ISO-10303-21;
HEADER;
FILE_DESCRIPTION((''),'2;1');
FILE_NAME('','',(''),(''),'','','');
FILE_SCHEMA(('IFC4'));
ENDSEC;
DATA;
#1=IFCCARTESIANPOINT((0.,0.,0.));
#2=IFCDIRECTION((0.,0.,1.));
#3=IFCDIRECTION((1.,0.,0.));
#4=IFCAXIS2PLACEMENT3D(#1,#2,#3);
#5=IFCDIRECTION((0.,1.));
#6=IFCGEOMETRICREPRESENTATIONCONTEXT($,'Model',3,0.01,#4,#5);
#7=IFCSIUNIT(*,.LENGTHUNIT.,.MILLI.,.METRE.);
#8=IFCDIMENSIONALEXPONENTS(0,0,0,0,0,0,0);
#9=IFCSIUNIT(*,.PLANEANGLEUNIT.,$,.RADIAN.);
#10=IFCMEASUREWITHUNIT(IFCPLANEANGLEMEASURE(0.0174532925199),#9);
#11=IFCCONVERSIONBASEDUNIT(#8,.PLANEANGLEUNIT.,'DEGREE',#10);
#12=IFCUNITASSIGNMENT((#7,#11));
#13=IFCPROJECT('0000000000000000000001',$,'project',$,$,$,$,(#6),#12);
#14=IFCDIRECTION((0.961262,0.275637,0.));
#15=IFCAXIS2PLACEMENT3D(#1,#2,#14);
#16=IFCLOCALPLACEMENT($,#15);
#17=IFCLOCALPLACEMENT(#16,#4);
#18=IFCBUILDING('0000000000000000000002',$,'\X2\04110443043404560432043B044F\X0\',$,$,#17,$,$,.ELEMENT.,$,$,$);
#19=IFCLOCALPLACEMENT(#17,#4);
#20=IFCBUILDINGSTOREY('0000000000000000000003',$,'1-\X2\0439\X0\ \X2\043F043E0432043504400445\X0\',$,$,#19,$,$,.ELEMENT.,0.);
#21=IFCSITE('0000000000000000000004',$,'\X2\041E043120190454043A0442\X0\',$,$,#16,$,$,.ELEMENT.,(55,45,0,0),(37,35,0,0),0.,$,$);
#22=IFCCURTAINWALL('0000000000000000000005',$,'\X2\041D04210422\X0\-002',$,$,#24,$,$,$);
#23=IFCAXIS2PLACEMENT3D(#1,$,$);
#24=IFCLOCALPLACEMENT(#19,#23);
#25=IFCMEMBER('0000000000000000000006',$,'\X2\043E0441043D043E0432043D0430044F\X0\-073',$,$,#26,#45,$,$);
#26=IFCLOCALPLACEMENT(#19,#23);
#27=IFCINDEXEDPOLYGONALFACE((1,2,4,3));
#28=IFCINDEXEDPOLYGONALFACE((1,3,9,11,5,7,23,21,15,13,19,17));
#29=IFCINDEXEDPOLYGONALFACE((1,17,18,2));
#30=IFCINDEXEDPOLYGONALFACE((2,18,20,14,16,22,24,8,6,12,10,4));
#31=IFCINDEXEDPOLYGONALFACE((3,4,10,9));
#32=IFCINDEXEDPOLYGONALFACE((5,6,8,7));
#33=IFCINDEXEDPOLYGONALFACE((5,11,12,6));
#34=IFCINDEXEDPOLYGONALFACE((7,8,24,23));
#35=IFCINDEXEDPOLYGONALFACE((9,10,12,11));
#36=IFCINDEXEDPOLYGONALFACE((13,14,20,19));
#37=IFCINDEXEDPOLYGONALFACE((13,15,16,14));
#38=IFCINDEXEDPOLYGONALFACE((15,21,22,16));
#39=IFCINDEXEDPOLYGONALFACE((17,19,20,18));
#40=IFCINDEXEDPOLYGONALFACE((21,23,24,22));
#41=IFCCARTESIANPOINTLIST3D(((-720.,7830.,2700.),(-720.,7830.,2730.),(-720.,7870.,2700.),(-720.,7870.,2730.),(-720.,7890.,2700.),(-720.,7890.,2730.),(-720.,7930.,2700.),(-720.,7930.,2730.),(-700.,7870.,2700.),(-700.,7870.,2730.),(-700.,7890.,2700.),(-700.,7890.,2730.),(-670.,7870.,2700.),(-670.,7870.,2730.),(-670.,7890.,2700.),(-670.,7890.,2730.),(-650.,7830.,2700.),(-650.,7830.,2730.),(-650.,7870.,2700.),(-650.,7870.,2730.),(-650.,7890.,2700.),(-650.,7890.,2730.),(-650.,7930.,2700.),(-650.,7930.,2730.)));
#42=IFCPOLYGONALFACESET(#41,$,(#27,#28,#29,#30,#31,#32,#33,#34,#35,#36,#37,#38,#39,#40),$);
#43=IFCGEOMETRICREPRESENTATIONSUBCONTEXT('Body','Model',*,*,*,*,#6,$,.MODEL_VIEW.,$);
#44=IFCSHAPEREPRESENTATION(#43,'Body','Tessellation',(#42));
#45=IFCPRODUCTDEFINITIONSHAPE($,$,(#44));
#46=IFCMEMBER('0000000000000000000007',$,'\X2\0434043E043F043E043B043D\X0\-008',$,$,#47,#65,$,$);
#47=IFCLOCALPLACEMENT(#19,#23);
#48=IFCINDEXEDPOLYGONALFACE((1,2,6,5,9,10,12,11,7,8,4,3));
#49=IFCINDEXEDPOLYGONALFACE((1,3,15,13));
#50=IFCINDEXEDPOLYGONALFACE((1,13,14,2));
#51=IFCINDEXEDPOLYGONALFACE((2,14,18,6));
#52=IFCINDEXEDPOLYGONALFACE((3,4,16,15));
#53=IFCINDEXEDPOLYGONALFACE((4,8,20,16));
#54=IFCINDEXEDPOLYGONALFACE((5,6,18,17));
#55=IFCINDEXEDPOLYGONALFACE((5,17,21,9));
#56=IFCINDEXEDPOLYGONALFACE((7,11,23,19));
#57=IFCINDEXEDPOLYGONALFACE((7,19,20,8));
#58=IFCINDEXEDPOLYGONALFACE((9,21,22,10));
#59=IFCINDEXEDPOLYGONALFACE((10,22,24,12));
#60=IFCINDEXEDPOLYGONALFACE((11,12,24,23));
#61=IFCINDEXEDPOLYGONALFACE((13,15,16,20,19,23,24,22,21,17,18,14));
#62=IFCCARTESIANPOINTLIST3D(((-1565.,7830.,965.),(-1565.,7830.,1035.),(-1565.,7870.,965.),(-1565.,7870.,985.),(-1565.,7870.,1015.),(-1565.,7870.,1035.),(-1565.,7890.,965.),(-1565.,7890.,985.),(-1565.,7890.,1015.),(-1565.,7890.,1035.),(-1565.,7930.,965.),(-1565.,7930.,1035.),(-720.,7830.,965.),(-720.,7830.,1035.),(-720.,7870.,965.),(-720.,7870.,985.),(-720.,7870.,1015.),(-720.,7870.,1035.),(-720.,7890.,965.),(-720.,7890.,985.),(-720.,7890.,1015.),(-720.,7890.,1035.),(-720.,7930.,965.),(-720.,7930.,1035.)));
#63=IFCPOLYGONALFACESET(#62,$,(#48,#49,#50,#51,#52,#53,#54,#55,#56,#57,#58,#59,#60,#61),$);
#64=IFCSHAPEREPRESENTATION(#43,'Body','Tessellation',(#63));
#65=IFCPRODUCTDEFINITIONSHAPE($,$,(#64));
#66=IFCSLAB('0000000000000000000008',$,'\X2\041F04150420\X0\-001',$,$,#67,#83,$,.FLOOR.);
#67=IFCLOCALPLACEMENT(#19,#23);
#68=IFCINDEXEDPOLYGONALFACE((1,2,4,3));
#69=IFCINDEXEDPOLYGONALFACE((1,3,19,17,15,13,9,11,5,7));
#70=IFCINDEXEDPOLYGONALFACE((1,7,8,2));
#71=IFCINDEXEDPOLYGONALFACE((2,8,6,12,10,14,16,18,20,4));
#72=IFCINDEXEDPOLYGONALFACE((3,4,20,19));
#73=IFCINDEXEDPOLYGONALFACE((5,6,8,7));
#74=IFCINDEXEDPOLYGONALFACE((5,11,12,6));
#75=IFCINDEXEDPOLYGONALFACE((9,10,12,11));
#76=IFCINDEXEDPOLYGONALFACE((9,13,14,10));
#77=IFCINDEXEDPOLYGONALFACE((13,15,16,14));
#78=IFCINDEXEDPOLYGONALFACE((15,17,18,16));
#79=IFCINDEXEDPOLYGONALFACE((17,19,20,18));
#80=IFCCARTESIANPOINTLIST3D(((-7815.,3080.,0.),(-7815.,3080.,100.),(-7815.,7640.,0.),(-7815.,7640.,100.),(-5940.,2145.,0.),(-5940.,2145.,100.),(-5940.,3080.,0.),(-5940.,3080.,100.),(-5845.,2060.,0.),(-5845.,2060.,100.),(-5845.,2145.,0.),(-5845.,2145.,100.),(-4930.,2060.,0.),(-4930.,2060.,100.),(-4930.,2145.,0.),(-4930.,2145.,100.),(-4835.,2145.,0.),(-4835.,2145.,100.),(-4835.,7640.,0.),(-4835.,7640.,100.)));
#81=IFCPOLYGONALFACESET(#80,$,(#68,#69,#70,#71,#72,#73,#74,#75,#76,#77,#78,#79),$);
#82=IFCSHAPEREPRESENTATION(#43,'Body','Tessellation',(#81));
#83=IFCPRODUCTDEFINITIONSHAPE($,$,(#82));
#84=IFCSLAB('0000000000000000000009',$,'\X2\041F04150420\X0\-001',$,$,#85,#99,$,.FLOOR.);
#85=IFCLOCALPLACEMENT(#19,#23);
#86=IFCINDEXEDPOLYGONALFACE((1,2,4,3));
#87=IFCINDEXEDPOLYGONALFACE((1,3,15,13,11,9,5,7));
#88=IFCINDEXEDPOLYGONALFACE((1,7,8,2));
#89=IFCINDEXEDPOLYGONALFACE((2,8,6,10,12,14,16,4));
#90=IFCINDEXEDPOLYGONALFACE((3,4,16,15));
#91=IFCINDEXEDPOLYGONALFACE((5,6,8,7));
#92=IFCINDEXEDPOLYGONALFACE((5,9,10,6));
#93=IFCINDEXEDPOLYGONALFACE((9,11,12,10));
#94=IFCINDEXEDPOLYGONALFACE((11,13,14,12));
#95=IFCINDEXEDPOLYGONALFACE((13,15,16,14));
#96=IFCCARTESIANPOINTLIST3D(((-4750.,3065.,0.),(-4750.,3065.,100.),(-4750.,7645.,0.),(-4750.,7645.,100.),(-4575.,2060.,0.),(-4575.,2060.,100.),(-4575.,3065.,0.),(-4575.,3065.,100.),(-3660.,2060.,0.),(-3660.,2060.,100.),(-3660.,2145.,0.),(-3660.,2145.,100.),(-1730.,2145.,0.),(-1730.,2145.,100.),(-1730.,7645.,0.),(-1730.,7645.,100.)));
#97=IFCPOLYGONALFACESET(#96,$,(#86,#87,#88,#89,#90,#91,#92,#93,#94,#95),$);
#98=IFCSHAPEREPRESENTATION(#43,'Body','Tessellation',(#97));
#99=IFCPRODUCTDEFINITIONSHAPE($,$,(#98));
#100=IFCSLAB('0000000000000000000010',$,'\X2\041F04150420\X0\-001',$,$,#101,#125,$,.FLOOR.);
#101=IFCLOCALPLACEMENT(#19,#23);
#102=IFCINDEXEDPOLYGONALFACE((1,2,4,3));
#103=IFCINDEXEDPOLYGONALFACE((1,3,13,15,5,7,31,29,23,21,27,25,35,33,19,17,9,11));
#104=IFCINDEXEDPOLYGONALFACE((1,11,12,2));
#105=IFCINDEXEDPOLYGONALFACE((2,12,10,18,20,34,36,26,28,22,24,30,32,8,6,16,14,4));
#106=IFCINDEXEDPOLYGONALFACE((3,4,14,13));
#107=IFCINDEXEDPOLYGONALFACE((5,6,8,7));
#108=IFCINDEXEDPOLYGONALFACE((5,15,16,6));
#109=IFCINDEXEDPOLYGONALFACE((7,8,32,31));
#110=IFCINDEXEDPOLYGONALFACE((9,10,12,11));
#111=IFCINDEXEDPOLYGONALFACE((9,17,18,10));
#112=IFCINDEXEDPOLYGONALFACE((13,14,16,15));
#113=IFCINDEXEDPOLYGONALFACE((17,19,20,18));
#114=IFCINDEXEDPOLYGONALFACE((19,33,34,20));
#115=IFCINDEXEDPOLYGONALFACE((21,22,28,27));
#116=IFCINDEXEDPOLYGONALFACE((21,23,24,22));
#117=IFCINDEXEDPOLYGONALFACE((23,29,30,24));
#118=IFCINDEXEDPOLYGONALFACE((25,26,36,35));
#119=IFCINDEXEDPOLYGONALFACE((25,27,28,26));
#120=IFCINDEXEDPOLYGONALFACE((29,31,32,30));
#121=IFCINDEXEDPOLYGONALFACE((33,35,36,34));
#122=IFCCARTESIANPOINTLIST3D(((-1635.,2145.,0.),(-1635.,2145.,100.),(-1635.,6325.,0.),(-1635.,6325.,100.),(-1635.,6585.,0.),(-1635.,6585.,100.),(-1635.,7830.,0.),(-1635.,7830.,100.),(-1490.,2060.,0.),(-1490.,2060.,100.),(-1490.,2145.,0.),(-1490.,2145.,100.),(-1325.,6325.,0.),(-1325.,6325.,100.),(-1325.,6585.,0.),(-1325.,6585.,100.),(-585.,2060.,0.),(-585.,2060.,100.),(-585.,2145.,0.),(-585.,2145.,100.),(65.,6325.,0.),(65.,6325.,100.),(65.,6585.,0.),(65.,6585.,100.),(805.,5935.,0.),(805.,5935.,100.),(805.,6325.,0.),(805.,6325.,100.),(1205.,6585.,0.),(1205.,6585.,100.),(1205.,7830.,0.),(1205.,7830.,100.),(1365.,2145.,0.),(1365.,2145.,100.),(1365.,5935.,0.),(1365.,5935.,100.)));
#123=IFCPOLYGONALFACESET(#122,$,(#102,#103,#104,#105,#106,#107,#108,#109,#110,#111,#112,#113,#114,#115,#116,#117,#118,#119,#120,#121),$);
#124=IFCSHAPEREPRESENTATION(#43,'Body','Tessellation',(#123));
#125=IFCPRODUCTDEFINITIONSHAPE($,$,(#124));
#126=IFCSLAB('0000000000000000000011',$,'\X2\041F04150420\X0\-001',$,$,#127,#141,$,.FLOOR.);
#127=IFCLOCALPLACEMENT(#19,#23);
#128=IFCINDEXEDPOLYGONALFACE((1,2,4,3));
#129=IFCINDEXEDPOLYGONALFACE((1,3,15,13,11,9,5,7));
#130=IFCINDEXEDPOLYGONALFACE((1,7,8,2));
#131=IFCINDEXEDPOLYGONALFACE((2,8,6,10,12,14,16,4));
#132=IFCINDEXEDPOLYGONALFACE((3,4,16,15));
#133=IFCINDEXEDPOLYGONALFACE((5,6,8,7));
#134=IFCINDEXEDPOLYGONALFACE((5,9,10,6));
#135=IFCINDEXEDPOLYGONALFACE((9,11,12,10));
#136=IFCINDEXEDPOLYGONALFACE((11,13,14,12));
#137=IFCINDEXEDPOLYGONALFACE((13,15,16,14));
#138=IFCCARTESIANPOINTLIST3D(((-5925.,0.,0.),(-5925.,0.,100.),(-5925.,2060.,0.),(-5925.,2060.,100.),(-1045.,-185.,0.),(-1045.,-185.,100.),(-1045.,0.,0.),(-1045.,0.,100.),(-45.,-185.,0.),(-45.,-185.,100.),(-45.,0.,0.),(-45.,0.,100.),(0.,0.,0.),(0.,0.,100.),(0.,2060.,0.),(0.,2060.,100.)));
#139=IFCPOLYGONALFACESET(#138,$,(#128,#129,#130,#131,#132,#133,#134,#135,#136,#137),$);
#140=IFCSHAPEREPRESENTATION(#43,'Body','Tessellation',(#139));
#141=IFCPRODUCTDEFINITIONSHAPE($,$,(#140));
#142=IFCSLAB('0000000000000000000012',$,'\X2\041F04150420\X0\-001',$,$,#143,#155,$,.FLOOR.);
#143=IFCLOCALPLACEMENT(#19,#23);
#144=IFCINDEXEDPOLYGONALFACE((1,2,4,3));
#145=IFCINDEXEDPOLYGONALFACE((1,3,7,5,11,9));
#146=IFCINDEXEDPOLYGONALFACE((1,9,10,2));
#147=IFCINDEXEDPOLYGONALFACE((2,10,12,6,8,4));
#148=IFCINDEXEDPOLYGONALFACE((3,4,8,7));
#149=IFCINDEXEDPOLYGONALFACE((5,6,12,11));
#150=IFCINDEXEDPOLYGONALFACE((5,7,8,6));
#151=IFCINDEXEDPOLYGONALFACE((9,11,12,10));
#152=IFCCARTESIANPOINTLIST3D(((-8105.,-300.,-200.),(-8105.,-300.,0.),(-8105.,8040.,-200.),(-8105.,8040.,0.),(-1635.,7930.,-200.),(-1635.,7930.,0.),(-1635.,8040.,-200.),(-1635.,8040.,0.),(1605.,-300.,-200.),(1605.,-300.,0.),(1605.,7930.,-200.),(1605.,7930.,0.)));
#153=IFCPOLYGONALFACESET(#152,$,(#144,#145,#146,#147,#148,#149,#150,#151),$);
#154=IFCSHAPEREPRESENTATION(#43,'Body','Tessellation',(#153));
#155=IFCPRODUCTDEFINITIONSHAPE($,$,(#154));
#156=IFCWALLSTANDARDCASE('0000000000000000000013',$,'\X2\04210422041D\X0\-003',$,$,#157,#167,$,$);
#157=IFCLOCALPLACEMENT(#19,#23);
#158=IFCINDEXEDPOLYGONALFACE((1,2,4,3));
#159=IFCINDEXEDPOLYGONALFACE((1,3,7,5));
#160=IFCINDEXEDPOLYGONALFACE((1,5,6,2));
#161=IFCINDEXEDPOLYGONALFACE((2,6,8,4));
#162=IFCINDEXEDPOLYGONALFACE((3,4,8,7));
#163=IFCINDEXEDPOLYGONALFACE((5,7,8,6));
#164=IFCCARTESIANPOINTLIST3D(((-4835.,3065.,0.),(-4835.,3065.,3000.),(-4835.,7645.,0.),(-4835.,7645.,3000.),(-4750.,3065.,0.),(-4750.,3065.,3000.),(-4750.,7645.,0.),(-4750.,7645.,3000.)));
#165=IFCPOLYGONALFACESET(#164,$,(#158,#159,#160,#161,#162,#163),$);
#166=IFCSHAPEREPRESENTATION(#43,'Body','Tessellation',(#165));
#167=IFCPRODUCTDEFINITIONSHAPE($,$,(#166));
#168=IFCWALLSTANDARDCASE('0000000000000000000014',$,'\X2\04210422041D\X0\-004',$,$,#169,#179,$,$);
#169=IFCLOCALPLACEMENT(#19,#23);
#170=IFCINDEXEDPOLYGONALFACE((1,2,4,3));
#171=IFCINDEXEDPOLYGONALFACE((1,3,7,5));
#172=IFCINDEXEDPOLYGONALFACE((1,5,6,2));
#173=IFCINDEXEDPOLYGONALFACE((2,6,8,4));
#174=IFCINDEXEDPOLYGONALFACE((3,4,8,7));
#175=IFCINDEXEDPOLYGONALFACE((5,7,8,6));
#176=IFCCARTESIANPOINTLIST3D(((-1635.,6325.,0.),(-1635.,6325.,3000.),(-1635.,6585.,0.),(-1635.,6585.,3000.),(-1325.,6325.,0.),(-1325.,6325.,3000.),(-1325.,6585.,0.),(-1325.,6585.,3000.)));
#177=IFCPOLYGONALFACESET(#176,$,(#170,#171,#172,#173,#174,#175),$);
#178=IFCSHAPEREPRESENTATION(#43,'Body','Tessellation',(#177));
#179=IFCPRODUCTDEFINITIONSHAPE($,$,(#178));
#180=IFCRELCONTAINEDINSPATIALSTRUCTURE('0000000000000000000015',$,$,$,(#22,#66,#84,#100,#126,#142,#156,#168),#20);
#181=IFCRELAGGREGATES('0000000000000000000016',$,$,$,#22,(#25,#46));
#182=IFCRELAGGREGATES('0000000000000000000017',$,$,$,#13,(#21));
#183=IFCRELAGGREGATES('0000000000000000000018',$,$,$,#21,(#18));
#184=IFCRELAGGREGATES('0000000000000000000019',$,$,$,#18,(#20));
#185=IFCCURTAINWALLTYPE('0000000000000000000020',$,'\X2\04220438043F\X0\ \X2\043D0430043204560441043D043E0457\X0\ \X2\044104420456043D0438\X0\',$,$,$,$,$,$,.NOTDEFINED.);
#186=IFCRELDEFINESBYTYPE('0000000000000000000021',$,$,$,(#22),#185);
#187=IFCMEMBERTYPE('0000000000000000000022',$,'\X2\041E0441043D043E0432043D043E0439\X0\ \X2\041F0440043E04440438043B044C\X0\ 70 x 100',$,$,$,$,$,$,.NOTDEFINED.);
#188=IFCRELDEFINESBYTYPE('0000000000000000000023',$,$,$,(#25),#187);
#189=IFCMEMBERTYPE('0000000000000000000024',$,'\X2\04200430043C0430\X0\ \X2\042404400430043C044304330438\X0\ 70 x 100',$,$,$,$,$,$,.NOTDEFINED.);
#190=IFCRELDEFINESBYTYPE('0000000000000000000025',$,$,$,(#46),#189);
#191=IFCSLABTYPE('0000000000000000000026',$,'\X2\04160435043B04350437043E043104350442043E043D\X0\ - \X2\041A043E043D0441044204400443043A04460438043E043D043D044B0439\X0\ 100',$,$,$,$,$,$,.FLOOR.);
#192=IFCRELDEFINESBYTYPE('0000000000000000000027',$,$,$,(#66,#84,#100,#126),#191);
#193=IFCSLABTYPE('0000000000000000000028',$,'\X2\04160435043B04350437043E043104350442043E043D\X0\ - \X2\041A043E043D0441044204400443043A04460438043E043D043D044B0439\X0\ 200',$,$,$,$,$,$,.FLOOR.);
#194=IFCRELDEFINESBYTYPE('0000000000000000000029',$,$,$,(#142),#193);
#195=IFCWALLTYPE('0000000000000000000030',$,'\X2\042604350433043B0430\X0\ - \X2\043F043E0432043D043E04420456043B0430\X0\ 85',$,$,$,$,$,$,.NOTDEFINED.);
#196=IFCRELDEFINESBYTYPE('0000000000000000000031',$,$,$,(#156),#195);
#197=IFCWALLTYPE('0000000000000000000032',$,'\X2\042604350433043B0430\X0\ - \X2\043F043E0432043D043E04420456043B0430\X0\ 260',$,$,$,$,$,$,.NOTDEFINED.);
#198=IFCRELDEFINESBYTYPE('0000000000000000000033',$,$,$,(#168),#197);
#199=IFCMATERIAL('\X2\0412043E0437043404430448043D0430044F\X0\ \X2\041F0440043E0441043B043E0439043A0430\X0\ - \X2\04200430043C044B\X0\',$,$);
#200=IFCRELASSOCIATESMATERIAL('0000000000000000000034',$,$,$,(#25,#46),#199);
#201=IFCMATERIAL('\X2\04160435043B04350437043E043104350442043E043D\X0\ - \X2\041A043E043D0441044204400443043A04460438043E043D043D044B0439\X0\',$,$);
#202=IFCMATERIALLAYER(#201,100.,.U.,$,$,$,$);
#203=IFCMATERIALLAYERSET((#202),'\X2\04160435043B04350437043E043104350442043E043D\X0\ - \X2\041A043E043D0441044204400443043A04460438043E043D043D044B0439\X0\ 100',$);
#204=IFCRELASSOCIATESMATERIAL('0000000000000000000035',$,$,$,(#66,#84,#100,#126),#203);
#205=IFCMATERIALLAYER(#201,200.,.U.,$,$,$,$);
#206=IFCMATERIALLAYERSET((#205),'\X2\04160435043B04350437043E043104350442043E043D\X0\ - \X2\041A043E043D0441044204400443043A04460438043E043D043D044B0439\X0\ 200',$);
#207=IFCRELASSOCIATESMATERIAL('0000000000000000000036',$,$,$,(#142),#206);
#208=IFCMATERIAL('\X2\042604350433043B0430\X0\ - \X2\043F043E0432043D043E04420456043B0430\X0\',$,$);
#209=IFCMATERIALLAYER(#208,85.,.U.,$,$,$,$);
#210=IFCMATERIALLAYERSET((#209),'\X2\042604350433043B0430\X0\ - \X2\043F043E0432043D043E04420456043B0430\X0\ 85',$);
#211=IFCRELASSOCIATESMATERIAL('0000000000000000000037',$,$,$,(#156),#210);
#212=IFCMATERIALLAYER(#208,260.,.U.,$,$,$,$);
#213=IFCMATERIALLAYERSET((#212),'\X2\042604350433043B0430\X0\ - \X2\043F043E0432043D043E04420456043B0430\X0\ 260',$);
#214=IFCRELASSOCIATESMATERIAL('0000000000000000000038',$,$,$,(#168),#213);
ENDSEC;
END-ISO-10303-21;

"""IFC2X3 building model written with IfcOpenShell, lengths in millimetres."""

from ifc_helpers import new_model, entity, si_unit, converted_unit, direction, frame, origin_with_axes, place, context, subcontext, project, spatial, polyline, outline, extrude, material, layer, layer_set, layer_usage, type_object, element, aggregate, save


model = new_model("IFC2X3")

# Units and contexts
model_context = context("Model", 3, precision=0.01, world=origin_with_axes(), true_north=direction((0.0, 1.0)))
body_context = subcontext(model_context, "Body", "Model", "MODEL_VIEW")
ifc_project = project(units=[si_unit("LENGTHUNIT", "METRE", prefix="MILLI"), converted_unit("PLANEANGLEUNIT", "DEGREE", entity("IfcPlaneAngleMeasure", 0.0174532925199), si_unit("PLANEANGLEUNIT", "RADIAN"), dimensions=[0, 0, 0, 0, 0, 0, 0])], contexts=[model_context])

# Site, building, storey
site_placement = place(None, frame((0.0, 0.0, 0.0), z_axis=(0.0, 0.0, 1.0), x_axis=(0.961262, 0.275637, 0.0)))
site = spatial("IfcSite", under=ifc_project, at=site_placement, Name="Об’єкт", CompositionType="ELEMENT", RefLatitude=(55, 45, 0, 0), RefLongitude=(37, 35, 0, 0), RefElevation=0.0)
building_placement = place(site_placement, origin_with_axes())
building = spatial("IfcBuilding", under=site, at=building_placement, Name="Будівля", CompositionType="ELEMENT")
storey_placement = place(building_placement, origin_with_axes())
storey = spatial("IfcBuildingStorey", under=building, at=storey_placement, Name="1-й поверх", CompositionType="ELEMENT", Elevation=0.0)

# Shared definitions
ifc_material_1 = material(Name="Железобетон - Конструкционный")

# Curtain wall, members
curtain_wall_type = type_object("IfcCurtainWallType", Name="Тип навісної стіни", PredefinedType="NOTDEFINED")
curtain_wall_placement = place(storey_placement, frame((-210.0, 7880.0, 100.0), z_axis=(0.0, 0.0, 1.0), x_axis=(1.0, 0.0, 0.0)))
curtain_wall = element("IfcCurtainWall", 1, at=curtain_wall_placement, inside=storey, type_object=curtain_wall_type, Name="НСТ-002")
ifc_material_2 = material(Name="Воздушная Прослойка - Рамы")
member_type_1 = type_object("IfcMemberType", Name="Основной Профиль 70 x 100", PredefinedType="NOTDEFINED")
member_1_placement = place(curtain_wall_placement, frame((-475.0, 0.0, 2600.0), z_axis=(0.0, 0.0, 1.0), x_axis=(1.0, 0.0, 0.0)))
member_1 = element("IfcMember", 2, at=member_1_placement, type_object=member_type_1, material=ifc_material_2, Name="основная-073", context=body_context, shape_type="SweptSolid", body=[
    extrude(outline(polyline([(-15.0, -10.0), (-35.0, -10.0), (-35.0, -50.0), (35.0, -50.0), (35.0, -10.0), (15.0, -10.0), (15.0, 10.0), (35.0, 10.0), (35.0, 50.0), (-35.0, 50.0), (-35.0, 10.0), (-15.0, 10.0), (-15.0, -10.0)])), origin_with_axes(), (0.0, 0.0, 1.0), 30.0),
])
member_type_2 = type_object("IfcMemberType", Name="Рама Фрамуги 70 x 100", PredefinedType="NOTDEFINED")
member_2_placement = place(curtain_wall_placement, frame((-475.0, 0.0, 900.0), z_axis=(-1.0, 0.0, 0.0), x_axis=(0.0, 0.0, 1.0)))
member_2 = element("IfcMember", 3, at=member_2_placement, type_object=member_type_2, material=ifc_material_2, Name="дополн-008", context=body_context, shape_type="SweptSolid", body=[
    extrude(outline(polyline([(-10.0, 15.0), (-10.0, 35.0), (-50.0, 35.0), (-50.0, -35.0), (-10.0, -35.0), (-10.0, -15.0), (10.0, -15.0), (10.0, -35.0), (50.0, -35.0), (50.0, 35.0), (10.0, 35.0), (10.0, 15.0), (-10.0, 15.0)])), frame((0.0, 0.0, 35.0), z_axis=(0.0, 0.0, 1.0), x_axis=(0.0, 1.0, 0.0)), (0.0, 0.0, 1.0), 845.0),
])

# Slabs
ifc_layer_1 = layer(ifc_material_1, 100.0, ventilated="UNKNOWN")
ifc_layer_set_1 = layer_set([ifc_layer_1], Name="Железобетон - Конструкционный 100")
ifc_layer_usage_1 = layer_usage(ifc_layer_set_1, "AXIS3", "NEGATIVE", 100.0)
slab_type_1 = type_object("IfcSlabType", Name="Железобетон - Конструкционный 100", PredefinedType="FLOOR")
slab_1_placement = place(storey_placement, frame((-4835.0, 7640.0, 100.0), z_axis=(0.0, 0.0, 1.0), x_axis=(1.0, 0.0, 0.0)))
element("IfcSlab", 4, at=slab_1_placement, inside=storey, type_object=slab_type_1, material=ifc_layer_usage_1, Name="ПЕР-001", PredefinedType="FLOOR", context=body_context, shape_type="SweptSolid", body=[
    extrude(outline(polyline([(0.0, 0.0), (-2980.0, 0.0), (-2980.0, -4560.0), (-1105.0, -4560.0), (-1105.0, -5495.0), (-1010.0, -5495.0), (-1010.0, -5580.0), (-95.0, -5580.0), (-95.0, -5495.0), (0.0, -5495.0), (0.0, 0.0)])), frame((0.0, 0.0, -100.0), z_axis=(0.0, 0.0, 1.0), x_axis=(1.0, 0.0, 0.0)), (0.0, 0.0, 1.0), 100.0),
])
ifc_layer_usage_2 = layer_usage(ifc_layer_set_1, "AXIS3", "NEGATIVE", 100.0)
slab_2_placement = place(storey_placement, frame((-1730.0, 7645.0, 100.0), z_axis=(0.0, 0.0, 1.0), x_axis=(1.0, 0.0, 0.0)))
element("IfcSlab", 5, at=slab_2_placement, inside=storey, type_object=slab_type_1, material=ifc_layer_usage_2, Name="ПЕР-001", PredefinedType="FLOOR", context=body_context, shape_type="SweptSolid", body=[
    extrude(outline(polyline([(0.0, 0.0), (-3020.0, 0.0), (-3020.0, -4580.0), (-2845.0, -4580.0), (-2845.0, -5585.0), (-1930.0, -5585.0), (-1930.0, -5500.0), (0.0, -5500.0), (0.0, 0.0)])), frame((0.0, 0.0, -100.0), z_axis=(0.0, 0.0, 1.0), x_axis=(1.0, 0.0, 0.0)), (0.0, 0.0, 1.0), 100.0),
])
ifc_layer_usage_3 = layer_usage(ifc_layer_set_1, "AXIS3", "NEGATIVE", 100.0)
slab_3_placement = place(storey_placement, frame((-1635.0, 6585.0, 100.0), z_axis=(0.0, 0.0, 1.0), x_axis=(1.0, 0.0, 0.0)))
element("IfcSlab", 6, at=slab_3_placement, inside=storey, type_object=slab_type_1, material=ifc_layer_usage_3, Name="ПЕР-001", PredefinedType="FLOOR", context=body_context, shape_type="SweptSolid", body=[
    extrude(outline(polyline([(0.0, 0.0), (310.0, 0.0), (310.0, -260.0), (0.0, -260.0), (0.0, -4440.0), (145.0, -4440.0), (145.0, -4525.0), (1050.0, -4525.0), (1050.0, -4440.0), (3000.0, -4440.0), (3000.0, -650.0), (2440.0, -650.0), (2440.0, -260.0), (1700.0, -260.0), (1700.0, 0.0), (2840.0, 0.0), (2840.0, 1245.0), (0.0, 1245.0), (0.0, 0.0)])), frame((0.0, 0.0, -100.0), z_axis=(0.0, 0.0, 1.0), x_axis=(1.0, 0.0, 0.0)), (0.0, 0.0, 1.0), 100.0),
])
ifc_layer_usage_4 = layer_usage(ifc_layer_set_1, "AXIS3", "NEGATIVE", 100.0)
slab_4_placement = place(storey_placement, frame((-5925.0, 0.0, 100.0), z_axis=(0.0, 0.0, 1.0), x_axis=(1.0, 0.0, 0.0)))
element("IfcSlab", 7, at=slab_4_placement, inside=storey, type_object=slab_type_1, material=ifc_layer_usage_4, Name="ПЕР-001", PredefinedType="FLOOR", context=body_context, shape_type="SweptSolid", body=[
    extrude(outline(polyline([(0.0, 0.0), (4880.0, 0.0), (4880.0, -185.0), (5880.0, -185.0), (5880.0, 0.0), (5925.0, 0.0), (5925.0, 2060.0), (0.0, 2060.0), (0.0, 0.0)])), frame((0.0, 0.0, -100.0), z_axis=(0.0, 0.0, 1.0), x_axis=(1.0, 0.0, 0.0)), (0.0, 0.0, 1.0), 100.0),
])

aggregate(curtain_wall, [member_1, member_2])

# Slab
ifc_layer_2 = layer(ifc_material_1, 200.0, ventilated="UNKNOWN")
ifc_layer_set_2 = layer_set([ifc_layer_2], Name="Железобетон - Конструкционный 200")
ifc_layer_usage_5 = layer_usage(ifc_layer_set_2, "AXIS3", "NEGATIVE", 200.0)
slab_type_2 = type_object("IfcSlabType", Name="Железобетон - Конструкционный 200", PredefinedType="FLOOR")
slab_5_placement = place(storey_placement, frame((-8105.0, 8040.0, 0.0), z_axis=(0.0, 0.0, 1.0), x_axis=(1.0, 0.0, 0.0)))
element("IfcSlab", 8, at=slab_5_placement, inside=storey, type_object=slab_type_2, material=ifc_layer_usage_5, Name="ПЕР-001", PredefinedType="FLOOR", context=body_context, shape_type="SweptSolid", body=[
    extrude(outline(polyline([(0.0, 0.0), (0.0, -8340.0), (9710.0, -8340.0), (9710.0, -110.0), (6470.0, -110.0), (6470.0, 0.0), (0.0, 0.0)])), frame((0.0, 0.0, -200.0), z_axis=(0.0, 0.0, 1.0), x_axis=(1.0, 0.0, 0.0)), (0.0, 0.0, 1.0), 200.0),
])

# Walls
ifc_material_3 = material(Name="Цегла - повнотіла")
ifc_layer_3 = layer(ifc_material_3, 85.0, ventilated="UNKNOWN")
ifc_layer_set_3 = layer_set([ifc_layer_3], Name="Цегла - повнотіла 85")
ifc_layer_usage_6 = layer_usage(ifc_layer_set_3, "AXIS2", "POSITIVE", 0.0)
wall_type_1 = type_object("IfcWallType", Name="Цегла - повнотіла 85", PredefinedType="NOTDEFINED")
wall_1_placement = place(storey_placement, frame((-4835.0, 7645.0, 0.0), z_axis=(0.0, 0.0, 1.0), x_axis=(0.0, -1.0, 0.0)))
element("IfcWallStandardCase", 9, at=wall_1_placement, inside=storey, type_object=wall_type_1, material=ifc_layer_usage_6, Name="СТН-003", context=body_context, shape_type="SweptSolid", body=[
    extrude(outline(polyline([(0.0, 0.0), (4580.0, 0.0), (4580.0, 85.0), (0.0, 85.0), (0.0, 0.0)])), origin_with_axes(), (0.0, 0.0, 1.0), 3000.0),
])
ifc_layer_4 = layer(ifc_material_3, 260.0, ventilated="UNKNOWN")
ifc_layer_set_4 = layer_set([ifc_layer_4], Name="Цегла - повнотіла 260")
ifc_layer_usage_7 = layer_usage(ifc_layer_set_4, "AXIS2", "POSITIVE", 0.0)
wall_type_2 = type_object("IfcWallType", Name="Цегла - повнотіла 260", PredefinedType="NOTDEFINED")
wall_2_placement = place(storey_placement, frame((-1325.0, 6585.0, 0.0), z_axis=(0.0, 0.0, 1.0), x_axis=(-1.0, 0.0, 0.0)))
element("IfcWallStandardCase", 10, at=wall_2_placement, inside=storey, type_object=wall_type_2, material=ifc_layer_usage_7, Name="СТН-004", context=body_context, shape_type="SweptSolid", body=[
    extrude(outline(polyline([(0.0, 0.0), (310.0, 0.0), (310.0, 260.0), (0.0, 260.0), (0.0, 0.0)])), origin_with_axes(), (0.0, 0.0, 1.0), 3000.0),
])

save(model, "model.ifc")
